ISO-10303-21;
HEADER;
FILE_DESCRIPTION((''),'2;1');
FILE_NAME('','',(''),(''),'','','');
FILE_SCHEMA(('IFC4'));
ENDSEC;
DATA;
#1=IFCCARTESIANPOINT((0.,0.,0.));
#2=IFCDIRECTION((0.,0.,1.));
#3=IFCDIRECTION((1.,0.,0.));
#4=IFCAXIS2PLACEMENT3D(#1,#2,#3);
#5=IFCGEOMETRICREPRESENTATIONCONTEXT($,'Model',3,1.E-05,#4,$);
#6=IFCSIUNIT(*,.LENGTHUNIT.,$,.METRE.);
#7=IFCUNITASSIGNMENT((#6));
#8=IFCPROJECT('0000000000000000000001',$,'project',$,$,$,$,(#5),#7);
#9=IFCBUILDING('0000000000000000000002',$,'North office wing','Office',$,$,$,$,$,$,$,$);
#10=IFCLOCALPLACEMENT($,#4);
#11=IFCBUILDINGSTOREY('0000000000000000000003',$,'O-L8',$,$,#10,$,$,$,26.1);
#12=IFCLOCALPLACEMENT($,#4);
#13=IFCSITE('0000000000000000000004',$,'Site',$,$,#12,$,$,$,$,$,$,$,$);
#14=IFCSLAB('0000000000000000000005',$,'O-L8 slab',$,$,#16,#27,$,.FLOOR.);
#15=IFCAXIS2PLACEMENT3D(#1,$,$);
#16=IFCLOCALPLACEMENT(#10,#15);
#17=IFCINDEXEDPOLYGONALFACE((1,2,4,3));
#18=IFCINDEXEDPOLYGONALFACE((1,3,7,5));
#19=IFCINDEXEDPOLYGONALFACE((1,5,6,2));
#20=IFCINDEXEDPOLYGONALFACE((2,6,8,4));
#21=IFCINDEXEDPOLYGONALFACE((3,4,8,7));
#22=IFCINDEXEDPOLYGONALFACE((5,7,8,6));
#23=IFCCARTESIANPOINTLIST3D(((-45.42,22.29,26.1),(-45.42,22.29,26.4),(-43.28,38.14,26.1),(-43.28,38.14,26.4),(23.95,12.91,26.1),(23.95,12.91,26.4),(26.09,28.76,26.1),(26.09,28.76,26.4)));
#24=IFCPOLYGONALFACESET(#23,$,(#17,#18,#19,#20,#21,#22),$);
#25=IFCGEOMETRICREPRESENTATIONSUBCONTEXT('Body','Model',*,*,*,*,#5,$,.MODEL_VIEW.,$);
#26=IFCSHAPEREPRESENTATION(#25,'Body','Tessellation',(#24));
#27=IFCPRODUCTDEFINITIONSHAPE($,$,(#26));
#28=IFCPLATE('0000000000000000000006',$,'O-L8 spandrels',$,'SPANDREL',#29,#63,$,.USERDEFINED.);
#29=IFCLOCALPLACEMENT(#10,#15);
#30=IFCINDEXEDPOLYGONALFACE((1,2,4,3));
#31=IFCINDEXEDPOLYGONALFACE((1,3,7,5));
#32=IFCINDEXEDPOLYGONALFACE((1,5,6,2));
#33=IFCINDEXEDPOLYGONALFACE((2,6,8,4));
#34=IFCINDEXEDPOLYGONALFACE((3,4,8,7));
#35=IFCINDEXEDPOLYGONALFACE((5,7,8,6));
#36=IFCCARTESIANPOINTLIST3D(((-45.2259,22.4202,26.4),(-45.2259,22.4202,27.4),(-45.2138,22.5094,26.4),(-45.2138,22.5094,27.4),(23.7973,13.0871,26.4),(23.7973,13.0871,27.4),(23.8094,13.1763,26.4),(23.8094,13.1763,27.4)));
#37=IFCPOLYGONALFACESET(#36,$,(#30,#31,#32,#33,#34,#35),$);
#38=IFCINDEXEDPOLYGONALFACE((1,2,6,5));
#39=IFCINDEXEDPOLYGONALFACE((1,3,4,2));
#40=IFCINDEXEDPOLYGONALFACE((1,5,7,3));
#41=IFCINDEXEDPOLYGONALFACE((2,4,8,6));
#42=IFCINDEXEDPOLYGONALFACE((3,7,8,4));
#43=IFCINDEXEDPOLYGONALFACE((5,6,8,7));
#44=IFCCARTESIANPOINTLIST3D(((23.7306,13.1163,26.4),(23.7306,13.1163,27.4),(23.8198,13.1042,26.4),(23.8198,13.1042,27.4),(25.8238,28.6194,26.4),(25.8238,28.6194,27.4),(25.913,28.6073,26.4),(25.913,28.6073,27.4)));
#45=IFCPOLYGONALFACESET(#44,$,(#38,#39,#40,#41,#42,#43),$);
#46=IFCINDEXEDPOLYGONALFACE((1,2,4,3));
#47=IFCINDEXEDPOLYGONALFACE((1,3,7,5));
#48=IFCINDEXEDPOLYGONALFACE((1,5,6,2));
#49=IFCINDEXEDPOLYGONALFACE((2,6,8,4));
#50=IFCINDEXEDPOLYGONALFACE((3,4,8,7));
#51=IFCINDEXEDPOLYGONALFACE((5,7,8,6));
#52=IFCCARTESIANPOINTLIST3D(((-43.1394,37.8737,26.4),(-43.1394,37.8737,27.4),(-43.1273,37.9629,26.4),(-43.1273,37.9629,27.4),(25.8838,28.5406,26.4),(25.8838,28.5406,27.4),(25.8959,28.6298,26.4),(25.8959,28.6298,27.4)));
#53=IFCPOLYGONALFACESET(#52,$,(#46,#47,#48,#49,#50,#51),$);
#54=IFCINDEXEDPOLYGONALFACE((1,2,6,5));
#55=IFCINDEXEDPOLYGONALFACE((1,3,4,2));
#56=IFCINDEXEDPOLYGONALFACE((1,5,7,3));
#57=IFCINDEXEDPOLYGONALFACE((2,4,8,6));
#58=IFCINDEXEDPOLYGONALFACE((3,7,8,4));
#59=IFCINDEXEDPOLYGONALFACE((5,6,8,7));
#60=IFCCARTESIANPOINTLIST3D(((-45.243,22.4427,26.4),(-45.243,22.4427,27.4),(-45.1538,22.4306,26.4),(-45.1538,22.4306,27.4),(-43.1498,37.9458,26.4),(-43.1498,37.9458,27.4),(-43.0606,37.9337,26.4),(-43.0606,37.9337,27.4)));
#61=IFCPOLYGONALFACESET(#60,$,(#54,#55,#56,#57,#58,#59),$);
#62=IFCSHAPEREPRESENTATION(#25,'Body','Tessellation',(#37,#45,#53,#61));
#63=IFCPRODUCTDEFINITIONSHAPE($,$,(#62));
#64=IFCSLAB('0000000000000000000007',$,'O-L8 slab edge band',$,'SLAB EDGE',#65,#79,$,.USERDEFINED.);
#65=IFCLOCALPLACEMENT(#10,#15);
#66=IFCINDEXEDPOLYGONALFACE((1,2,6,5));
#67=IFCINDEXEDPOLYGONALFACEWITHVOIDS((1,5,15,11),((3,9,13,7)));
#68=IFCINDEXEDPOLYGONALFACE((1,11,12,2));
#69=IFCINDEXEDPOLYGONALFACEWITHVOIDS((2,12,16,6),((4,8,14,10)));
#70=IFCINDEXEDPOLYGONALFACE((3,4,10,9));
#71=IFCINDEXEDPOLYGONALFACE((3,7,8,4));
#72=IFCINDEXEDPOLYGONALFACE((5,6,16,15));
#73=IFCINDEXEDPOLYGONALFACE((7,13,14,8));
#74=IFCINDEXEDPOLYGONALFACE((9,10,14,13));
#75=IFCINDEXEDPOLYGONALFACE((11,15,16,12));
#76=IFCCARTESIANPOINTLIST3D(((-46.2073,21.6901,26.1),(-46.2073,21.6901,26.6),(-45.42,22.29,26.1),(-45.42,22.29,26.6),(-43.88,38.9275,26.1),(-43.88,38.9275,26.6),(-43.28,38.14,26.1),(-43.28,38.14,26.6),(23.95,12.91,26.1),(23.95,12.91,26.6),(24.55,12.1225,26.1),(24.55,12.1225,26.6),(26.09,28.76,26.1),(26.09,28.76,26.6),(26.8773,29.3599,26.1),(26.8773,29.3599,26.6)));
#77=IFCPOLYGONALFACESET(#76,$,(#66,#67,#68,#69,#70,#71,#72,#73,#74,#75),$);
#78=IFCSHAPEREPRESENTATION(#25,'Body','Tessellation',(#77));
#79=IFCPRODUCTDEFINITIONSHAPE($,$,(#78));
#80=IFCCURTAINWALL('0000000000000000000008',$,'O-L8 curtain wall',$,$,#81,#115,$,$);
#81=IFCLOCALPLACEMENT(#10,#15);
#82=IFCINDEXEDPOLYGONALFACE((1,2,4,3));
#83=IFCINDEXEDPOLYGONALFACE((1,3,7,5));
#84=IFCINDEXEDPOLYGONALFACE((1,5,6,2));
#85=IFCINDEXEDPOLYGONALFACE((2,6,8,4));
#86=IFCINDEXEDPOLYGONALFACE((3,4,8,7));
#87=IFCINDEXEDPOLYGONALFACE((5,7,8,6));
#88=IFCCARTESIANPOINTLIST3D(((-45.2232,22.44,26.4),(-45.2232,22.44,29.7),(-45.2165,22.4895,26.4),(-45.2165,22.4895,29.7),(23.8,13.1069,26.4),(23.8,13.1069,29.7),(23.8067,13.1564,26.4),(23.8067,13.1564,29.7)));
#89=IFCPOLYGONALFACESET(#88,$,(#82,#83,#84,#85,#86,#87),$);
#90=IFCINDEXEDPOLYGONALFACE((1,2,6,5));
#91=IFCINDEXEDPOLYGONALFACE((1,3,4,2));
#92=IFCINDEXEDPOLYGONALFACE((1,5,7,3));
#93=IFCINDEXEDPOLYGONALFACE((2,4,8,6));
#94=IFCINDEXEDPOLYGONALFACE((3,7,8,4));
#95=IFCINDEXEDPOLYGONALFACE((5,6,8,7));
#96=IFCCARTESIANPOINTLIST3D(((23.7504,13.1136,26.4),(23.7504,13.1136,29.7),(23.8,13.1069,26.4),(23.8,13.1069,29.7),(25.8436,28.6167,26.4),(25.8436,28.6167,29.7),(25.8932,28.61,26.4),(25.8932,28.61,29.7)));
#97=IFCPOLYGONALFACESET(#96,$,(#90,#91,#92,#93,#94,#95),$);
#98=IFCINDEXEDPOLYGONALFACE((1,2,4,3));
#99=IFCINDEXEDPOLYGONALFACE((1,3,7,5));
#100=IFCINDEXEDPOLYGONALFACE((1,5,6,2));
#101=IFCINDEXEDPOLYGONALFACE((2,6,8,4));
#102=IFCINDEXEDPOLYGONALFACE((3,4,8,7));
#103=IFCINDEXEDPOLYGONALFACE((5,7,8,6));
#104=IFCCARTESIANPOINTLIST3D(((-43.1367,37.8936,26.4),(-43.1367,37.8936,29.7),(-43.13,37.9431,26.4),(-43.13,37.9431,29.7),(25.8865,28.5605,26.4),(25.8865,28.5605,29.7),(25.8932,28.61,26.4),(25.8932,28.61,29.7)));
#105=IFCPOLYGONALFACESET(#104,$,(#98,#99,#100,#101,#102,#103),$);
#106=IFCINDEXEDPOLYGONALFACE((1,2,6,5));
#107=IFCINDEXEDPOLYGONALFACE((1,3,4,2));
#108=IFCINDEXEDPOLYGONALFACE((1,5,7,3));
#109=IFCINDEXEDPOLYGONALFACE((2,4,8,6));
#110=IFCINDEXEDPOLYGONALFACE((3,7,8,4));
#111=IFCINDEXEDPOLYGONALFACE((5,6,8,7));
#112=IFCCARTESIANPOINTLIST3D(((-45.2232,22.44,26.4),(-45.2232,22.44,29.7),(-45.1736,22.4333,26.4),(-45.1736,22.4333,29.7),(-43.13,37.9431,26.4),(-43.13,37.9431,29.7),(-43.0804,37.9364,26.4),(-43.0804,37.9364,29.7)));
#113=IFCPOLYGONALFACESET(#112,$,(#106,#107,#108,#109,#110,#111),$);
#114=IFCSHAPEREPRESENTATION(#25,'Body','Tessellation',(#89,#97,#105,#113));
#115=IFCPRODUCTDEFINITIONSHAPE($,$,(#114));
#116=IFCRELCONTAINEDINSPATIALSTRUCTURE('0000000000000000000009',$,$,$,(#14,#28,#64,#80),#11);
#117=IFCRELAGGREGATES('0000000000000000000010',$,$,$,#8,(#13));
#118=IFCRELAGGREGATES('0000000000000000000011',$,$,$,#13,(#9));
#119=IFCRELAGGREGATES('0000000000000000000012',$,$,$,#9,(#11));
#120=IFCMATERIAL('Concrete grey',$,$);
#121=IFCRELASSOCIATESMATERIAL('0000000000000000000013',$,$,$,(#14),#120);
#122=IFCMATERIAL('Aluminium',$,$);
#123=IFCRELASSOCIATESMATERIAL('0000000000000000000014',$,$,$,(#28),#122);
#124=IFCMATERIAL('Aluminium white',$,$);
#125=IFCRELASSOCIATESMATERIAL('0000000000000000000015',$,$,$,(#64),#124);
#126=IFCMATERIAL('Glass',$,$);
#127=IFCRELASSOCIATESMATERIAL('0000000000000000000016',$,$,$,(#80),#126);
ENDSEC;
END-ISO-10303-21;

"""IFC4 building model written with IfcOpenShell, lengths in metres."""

from ifc_helpers import new_model, si_unit, frame, origin_with_axes, place, context, subcontext, project, spatial, polyline, outline, extrude, material, element, save


model = new_model("IFC4")

# Units and contexts
model_context = context("Model", 3, precision=1e-05, world=origin_with_axes())
body_context = subcontext(model_context, "Body", "Model", "MODEL_VIEW")
ifc_project = project(units=[si_unit("LENGTHUNIT", "METRE")], contexts=[model_context])

# Site, building, storey
site_placement = place(None, origin_with_axes())
site = spatial("IfcSite", under=ifc_project, at=site_placement, Name="Site")
building = spatial("IfcBuilding", under=site, Name="North office wing", Description="Office")
storey_placement = place(None, origin_with_axes())
storey = spatial("IfcBuildingStorey", under=building, at=storey_placement, Name="O-L8", Elevation=26.1)

# Shared definitions
ifc_material_1 = material(Name="Aluminium")

# Slab
ifc_material_2 = material(Name="Concrete grey")
slab_1_placement = place(storey_placement, origin_with_axes())
element("IfcSlab", 1, at=slab_1_placement, inside=storey, material=ifc_material_2, Name="O-L8 slab", PredefinedType="FLOOR", context=body_context, shape_type="SweptSolid", body=[
    extrude(outline(polyline([(-45.42, 22.29), (23.95, 12.91), (26.09, 28.76), (-43.28, 38.14), (-45.42, 22.29)])), frame((0.0, 0.0, 26.1), z_axis=(0.0, 0.0, 1.0), x_axis=(1.0, 0.0, 0.0)), (0.0, 0.0, 1.0), 0.3),
])

# Plate
plate_placement = place(storey_placement, origin_with_axes())
element("IfcPlate", 2, at=plate_placement, inside=storey, material=ifc_material_1, Name="O-L8 spandrels", ObjectType="SPANDREL", PredefinedType="USERDEFINED", context=body_context, shape_type="SweptSolid", body=[
    extrude(outline(polyline([(-45.2259, 22.4202), (23.7973, 13.0871), (23.8094, 13.1763), (-45.2138, 22.5094), (-45.2259, 22.4202)])), frame((0.0, 0.0, 26.4), z_axis=(0.0, 0.0, 1.0), x_axis=(1.0, 0.0, 0.0)), (0.0, 0.0, 1.0), 1.0),
    extrude(outline(polyline([(23.8198, 13.1042), (25.913, 28.6073), (25.8238, 28.6194), (23.7306, 13.1163), (23.8198, 13.1042)])), frame((0.0, 0.0, 26.4), z_axis=(0.0, 0.0, 1.0), x_axis=(1.0, 0.0, 0.0)), (0.0, 0.0, 1.0), 1.0),
    extrude(outline(polyline([(25.8959, 28.6298), (-43.1273, 37.9629), (-43.1394, 37.8737), (25.8838, 28.5406), (25.8959, 28.6298)])), frame((0.0, 0.0, 26.4), z_axis=(0.0, 0.0, 1.0), x_axis=(1.0, 0.0, 0.0)), (0.0, 0.0, 1.0), 1.0),
    extrude(outline(polyline([(-43.1498, 37.9458), (-45.243, 22.4427), (-45.1538, 22.4306), (-43.0606, 37.9337), (-43.1498, 37.9458)])), frame((0.0, 0.0, 26.4), z_axis=(0.0, 0.0, 1.0), x_axis=(1.0, 0.0, 0.0)), (0.0, 0.0, 1.0), 1.0),
])

# Slab
ifc_material_3 = material(Name="Aluminium white")
slab_2_placement = place(storey_placement, origin_with_axes())
element("IfcSlab", 3, at=slab_2_placement, inside=storey, material=ifc_material_3, Name="O-L8 slab edge band", ObjectType="SLAB EDGE", PredefinedType="USERDEFINED", context=body_context, shape_type="SweptSolid", body=[
    extrude(outline(polyline([(-46.2073, 21.6901), (24.55, 12.1225), (26.8773, 29.3599), (-43.88, 38.9275), (-46.2073, 21.6901)]), holes=[polyline([(-45.42, 22.29), (23.95, 12.91), (26.09, 28.76), (-43.28, 38.14), (-45.42, 22.29)])]), frame((0.0, 0.0, 26.1), z_axis=(0.0, 0.0, 1.0), x_axis=(1.0, 0.0, 0.0)), (0.0, 0.0, 1.0), 0.5),
])

# Curtain wall
ifc_material_4 = material(Name="Glass")
curtain_wall_placement = place(storey_placement, origin_with_axes())
element("IfcCurtainWall", 4, at=curtain_wall_placement, inside=storey, material=ifc_material_4, Name="O-L8 curtain wall", context=body_context, shape_type="SweptSolid", body=[
    extrude(outline(polyline([(-45.2232, 22.44), (23.8, 13.1069), (23.8067, 13.1564), (-45.2165, 22.4895), (-45.2232, 22.44)])), frame((0.0, 0.0, 26.4), z_axis=(0.0, 0.0, 1.0), x_axis=(1.0, 0.0, 0.0)), (0.0, 0.0, 1.0), 3.3),
    extrude(outline(polyline([(23.8, 13.1069), (25.8932, 28.61), (25.8436, 28.6167), (23.7504, 13.1136), (23.8, 13.1069)])), frame((0.0, 0.0, 26.4), z_axis=(0.0, 0.0, 1.0), x_axis=(1.0, 0.0, 0.0)), (0.0, 0.0, 1.0), 3.3),
    extrude(outline(polyline([(25.8932, 28.61), (-43.13, 37.9431), (-43.1367, 37.8936), (25.8865, 28.5605), (25.8932, 28.61)])), frame((0.0, 0.0, 26.4), z_axis=(0.0, 0.0, 1.0), x_axis=(1.0, 0.0, 0.0)), (0.0, 0.0, 1.0), 3.3),
    extrude(outline(polyline([(-43.13, 37.9431), (-45.2232, 22.44), (-45.1736, 22.4333), (-43.0804, 37.9364), (-43.13, 37.9431)])), frame((0.0, 0.0, 26.4), z_axis=(0.0, 0.0, 1.0), x_axis=(1.0, 0.0, 0.0)), (0.0, 0.0, 1.0), 3.3),
])

save(model, "model.ifc")
